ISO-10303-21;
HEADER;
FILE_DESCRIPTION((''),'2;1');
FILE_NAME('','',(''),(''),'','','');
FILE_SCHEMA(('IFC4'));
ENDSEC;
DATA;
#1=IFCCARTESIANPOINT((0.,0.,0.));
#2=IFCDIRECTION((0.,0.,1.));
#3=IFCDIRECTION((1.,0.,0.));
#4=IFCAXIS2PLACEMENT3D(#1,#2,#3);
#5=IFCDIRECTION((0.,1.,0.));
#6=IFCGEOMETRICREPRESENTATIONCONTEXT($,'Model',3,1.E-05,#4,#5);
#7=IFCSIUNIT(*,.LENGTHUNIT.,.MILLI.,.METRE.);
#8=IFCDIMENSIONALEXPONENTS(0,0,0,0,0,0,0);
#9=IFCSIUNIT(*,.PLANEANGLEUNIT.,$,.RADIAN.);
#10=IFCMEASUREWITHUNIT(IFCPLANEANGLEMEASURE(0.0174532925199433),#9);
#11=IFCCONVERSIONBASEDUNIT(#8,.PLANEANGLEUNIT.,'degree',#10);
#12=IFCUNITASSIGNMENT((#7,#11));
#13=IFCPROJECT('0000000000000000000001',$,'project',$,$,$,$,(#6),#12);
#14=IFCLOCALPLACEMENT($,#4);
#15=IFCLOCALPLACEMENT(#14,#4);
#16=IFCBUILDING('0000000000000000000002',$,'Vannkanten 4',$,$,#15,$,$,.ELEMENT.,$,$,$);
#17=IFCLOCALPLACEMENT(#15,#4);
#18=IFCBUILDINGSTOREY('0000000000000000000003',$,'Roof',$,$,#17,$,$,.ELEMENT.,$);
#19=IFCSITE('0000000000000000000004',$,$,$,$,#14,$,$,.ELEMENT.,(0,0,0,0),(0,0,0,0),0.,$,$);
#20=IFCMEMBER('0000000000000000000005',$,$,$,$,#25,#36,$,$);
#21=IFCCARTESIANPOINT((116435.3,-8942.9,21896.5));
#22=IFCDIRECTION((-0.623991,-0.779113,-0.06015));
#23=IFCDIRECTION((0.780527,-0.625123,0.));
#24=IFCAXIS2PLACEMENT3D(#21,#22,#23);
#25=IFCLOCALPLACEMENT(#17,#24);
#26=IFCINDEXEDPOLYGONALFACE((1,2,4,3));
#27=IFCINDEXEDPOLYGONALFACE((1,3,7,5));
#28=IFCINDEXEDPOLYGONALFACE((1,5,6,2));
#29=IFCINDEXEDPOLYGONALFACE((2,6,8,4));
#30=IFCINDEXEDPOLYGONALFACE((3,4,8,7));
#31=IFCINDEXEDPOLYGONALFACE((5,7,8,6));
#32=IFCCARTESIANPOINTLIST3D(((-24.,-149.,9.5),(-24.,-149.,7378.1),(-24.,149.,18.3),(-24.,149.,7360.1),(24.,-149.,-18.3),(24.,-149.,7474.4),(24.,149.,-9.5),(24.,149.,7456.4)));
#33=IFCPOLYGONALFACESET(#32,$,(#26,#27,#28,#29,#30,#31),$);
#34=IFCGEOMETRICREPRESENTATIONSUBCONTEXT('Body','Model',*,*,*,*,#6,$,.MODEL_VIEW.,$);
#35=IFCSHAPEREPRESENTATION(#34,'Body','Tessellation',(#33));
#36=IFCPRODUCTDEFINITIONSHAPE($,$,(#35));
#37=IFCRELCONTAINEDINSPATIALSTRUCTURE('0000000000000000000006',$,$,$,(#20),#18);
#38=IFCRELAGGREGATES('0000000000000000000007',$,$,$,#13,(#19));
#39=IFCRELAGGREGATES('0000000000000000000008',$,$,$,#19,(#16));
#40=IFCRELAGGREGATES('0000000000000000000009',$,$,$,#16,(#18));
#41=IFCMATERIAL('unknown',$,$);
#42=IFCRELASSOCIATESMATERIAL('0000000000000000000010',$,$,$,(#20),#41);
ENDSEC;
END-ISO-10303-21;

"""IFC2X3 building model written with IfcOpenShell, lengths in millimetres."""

from ifc_helpers import new_model, entity, si_unit, converted_unit, direction, frame, origin_with_axes, place, context, subcontext, project, spatial, polyline, segment, composite_curve, outline, extrude, clip, halfspace, material, element, save


model = new_model("IFC2X3")

# Units and contexts
model_context = context("Model", 3, precision=1e-05, world=origin_with_axes(), true_north=direction((0.0, 1.0, 0.0)))
body_context = subcontext(model_context, "Body", "Model", "MODEL_VIEW")
ifc_project = project(units=[si_unit("LENGTHUNIT", "METRE", prefix="MILLI"), converted_unit("PLANEANGLEUNIT", "degree", entity("IfcPlaneAngleMeasure", 0.0174532925199433), si_unit("PLANEANGLEUNIT", "RADIAN"), dimensions=[0, 0, 0, 0, 0, 0, 0])], contexts=[model_context])

# Site, building, storey
site_placement = place(None, origin_with_axes())
site = spatial("IfcSite", under=ifc_project, at=site_placement, CompositionType="ELEMENT", RefLatitude=(0, 0, 0, 0), RefLongitude=(0, 0, 0, 0), RefElevation=0.0)
building_placement = place(site_placement, origin_with_axes())
building = spatial("IfcBuilding", under=site, at=building_placement, Name="Vannkanten 4", CompositionType="ELEMENT")
storey_placement = place(building_placement, origin_with_axes())
storey = spatial("IfcBuildingStorey", under=building, at=storey_placement, Name="Roof", CompositionType="ELEMENT")

# Member
ifc_material = material(Name="unknown")
member_1_placement = place(storey_placement, frame((116435.3, -8942.9, 21896.5), z_axis=(-0.623991, -0.779113, -0.06015), x_axis=(0.780527, -0.625123, 0.0)))
element("IfcMember", 1, at=member_1_placement, inside=storey, material=ifc_material, context=body_context, shape_type="Clipping", body=[
    clip(clip(extrude(outline(composite_curve([segment(polyline([(-24.0, -149.0), (-24.0, 149.0), (24.0, 149.0), (24.0, -149.0), (-24.0, -149.0)]), True, "CONTINUOUS")], self_intersect=False)), frame((0.0, 0.0, -3764.7), z_axis=(0.0, 0.0, 1.0), x_axis=(1.0, 0.0, 0.0)), (0.0, 0.0, 1.0), 14985.4), halfspace(frame((-24.0, 149.0, 18.3), z_axis=(0.502219, -0.025531, 0.864363), x_axis=(0.864645, 0.0, -0.502383)), True)), halfspace(frame((24.0, 149.0, 7456.4), z_axis=(0.894664, -0.026871, -0.445932), x_axis=(-0.446093, 0.0, -0.894987)), True)),
])

save(model, "model.ifc")
